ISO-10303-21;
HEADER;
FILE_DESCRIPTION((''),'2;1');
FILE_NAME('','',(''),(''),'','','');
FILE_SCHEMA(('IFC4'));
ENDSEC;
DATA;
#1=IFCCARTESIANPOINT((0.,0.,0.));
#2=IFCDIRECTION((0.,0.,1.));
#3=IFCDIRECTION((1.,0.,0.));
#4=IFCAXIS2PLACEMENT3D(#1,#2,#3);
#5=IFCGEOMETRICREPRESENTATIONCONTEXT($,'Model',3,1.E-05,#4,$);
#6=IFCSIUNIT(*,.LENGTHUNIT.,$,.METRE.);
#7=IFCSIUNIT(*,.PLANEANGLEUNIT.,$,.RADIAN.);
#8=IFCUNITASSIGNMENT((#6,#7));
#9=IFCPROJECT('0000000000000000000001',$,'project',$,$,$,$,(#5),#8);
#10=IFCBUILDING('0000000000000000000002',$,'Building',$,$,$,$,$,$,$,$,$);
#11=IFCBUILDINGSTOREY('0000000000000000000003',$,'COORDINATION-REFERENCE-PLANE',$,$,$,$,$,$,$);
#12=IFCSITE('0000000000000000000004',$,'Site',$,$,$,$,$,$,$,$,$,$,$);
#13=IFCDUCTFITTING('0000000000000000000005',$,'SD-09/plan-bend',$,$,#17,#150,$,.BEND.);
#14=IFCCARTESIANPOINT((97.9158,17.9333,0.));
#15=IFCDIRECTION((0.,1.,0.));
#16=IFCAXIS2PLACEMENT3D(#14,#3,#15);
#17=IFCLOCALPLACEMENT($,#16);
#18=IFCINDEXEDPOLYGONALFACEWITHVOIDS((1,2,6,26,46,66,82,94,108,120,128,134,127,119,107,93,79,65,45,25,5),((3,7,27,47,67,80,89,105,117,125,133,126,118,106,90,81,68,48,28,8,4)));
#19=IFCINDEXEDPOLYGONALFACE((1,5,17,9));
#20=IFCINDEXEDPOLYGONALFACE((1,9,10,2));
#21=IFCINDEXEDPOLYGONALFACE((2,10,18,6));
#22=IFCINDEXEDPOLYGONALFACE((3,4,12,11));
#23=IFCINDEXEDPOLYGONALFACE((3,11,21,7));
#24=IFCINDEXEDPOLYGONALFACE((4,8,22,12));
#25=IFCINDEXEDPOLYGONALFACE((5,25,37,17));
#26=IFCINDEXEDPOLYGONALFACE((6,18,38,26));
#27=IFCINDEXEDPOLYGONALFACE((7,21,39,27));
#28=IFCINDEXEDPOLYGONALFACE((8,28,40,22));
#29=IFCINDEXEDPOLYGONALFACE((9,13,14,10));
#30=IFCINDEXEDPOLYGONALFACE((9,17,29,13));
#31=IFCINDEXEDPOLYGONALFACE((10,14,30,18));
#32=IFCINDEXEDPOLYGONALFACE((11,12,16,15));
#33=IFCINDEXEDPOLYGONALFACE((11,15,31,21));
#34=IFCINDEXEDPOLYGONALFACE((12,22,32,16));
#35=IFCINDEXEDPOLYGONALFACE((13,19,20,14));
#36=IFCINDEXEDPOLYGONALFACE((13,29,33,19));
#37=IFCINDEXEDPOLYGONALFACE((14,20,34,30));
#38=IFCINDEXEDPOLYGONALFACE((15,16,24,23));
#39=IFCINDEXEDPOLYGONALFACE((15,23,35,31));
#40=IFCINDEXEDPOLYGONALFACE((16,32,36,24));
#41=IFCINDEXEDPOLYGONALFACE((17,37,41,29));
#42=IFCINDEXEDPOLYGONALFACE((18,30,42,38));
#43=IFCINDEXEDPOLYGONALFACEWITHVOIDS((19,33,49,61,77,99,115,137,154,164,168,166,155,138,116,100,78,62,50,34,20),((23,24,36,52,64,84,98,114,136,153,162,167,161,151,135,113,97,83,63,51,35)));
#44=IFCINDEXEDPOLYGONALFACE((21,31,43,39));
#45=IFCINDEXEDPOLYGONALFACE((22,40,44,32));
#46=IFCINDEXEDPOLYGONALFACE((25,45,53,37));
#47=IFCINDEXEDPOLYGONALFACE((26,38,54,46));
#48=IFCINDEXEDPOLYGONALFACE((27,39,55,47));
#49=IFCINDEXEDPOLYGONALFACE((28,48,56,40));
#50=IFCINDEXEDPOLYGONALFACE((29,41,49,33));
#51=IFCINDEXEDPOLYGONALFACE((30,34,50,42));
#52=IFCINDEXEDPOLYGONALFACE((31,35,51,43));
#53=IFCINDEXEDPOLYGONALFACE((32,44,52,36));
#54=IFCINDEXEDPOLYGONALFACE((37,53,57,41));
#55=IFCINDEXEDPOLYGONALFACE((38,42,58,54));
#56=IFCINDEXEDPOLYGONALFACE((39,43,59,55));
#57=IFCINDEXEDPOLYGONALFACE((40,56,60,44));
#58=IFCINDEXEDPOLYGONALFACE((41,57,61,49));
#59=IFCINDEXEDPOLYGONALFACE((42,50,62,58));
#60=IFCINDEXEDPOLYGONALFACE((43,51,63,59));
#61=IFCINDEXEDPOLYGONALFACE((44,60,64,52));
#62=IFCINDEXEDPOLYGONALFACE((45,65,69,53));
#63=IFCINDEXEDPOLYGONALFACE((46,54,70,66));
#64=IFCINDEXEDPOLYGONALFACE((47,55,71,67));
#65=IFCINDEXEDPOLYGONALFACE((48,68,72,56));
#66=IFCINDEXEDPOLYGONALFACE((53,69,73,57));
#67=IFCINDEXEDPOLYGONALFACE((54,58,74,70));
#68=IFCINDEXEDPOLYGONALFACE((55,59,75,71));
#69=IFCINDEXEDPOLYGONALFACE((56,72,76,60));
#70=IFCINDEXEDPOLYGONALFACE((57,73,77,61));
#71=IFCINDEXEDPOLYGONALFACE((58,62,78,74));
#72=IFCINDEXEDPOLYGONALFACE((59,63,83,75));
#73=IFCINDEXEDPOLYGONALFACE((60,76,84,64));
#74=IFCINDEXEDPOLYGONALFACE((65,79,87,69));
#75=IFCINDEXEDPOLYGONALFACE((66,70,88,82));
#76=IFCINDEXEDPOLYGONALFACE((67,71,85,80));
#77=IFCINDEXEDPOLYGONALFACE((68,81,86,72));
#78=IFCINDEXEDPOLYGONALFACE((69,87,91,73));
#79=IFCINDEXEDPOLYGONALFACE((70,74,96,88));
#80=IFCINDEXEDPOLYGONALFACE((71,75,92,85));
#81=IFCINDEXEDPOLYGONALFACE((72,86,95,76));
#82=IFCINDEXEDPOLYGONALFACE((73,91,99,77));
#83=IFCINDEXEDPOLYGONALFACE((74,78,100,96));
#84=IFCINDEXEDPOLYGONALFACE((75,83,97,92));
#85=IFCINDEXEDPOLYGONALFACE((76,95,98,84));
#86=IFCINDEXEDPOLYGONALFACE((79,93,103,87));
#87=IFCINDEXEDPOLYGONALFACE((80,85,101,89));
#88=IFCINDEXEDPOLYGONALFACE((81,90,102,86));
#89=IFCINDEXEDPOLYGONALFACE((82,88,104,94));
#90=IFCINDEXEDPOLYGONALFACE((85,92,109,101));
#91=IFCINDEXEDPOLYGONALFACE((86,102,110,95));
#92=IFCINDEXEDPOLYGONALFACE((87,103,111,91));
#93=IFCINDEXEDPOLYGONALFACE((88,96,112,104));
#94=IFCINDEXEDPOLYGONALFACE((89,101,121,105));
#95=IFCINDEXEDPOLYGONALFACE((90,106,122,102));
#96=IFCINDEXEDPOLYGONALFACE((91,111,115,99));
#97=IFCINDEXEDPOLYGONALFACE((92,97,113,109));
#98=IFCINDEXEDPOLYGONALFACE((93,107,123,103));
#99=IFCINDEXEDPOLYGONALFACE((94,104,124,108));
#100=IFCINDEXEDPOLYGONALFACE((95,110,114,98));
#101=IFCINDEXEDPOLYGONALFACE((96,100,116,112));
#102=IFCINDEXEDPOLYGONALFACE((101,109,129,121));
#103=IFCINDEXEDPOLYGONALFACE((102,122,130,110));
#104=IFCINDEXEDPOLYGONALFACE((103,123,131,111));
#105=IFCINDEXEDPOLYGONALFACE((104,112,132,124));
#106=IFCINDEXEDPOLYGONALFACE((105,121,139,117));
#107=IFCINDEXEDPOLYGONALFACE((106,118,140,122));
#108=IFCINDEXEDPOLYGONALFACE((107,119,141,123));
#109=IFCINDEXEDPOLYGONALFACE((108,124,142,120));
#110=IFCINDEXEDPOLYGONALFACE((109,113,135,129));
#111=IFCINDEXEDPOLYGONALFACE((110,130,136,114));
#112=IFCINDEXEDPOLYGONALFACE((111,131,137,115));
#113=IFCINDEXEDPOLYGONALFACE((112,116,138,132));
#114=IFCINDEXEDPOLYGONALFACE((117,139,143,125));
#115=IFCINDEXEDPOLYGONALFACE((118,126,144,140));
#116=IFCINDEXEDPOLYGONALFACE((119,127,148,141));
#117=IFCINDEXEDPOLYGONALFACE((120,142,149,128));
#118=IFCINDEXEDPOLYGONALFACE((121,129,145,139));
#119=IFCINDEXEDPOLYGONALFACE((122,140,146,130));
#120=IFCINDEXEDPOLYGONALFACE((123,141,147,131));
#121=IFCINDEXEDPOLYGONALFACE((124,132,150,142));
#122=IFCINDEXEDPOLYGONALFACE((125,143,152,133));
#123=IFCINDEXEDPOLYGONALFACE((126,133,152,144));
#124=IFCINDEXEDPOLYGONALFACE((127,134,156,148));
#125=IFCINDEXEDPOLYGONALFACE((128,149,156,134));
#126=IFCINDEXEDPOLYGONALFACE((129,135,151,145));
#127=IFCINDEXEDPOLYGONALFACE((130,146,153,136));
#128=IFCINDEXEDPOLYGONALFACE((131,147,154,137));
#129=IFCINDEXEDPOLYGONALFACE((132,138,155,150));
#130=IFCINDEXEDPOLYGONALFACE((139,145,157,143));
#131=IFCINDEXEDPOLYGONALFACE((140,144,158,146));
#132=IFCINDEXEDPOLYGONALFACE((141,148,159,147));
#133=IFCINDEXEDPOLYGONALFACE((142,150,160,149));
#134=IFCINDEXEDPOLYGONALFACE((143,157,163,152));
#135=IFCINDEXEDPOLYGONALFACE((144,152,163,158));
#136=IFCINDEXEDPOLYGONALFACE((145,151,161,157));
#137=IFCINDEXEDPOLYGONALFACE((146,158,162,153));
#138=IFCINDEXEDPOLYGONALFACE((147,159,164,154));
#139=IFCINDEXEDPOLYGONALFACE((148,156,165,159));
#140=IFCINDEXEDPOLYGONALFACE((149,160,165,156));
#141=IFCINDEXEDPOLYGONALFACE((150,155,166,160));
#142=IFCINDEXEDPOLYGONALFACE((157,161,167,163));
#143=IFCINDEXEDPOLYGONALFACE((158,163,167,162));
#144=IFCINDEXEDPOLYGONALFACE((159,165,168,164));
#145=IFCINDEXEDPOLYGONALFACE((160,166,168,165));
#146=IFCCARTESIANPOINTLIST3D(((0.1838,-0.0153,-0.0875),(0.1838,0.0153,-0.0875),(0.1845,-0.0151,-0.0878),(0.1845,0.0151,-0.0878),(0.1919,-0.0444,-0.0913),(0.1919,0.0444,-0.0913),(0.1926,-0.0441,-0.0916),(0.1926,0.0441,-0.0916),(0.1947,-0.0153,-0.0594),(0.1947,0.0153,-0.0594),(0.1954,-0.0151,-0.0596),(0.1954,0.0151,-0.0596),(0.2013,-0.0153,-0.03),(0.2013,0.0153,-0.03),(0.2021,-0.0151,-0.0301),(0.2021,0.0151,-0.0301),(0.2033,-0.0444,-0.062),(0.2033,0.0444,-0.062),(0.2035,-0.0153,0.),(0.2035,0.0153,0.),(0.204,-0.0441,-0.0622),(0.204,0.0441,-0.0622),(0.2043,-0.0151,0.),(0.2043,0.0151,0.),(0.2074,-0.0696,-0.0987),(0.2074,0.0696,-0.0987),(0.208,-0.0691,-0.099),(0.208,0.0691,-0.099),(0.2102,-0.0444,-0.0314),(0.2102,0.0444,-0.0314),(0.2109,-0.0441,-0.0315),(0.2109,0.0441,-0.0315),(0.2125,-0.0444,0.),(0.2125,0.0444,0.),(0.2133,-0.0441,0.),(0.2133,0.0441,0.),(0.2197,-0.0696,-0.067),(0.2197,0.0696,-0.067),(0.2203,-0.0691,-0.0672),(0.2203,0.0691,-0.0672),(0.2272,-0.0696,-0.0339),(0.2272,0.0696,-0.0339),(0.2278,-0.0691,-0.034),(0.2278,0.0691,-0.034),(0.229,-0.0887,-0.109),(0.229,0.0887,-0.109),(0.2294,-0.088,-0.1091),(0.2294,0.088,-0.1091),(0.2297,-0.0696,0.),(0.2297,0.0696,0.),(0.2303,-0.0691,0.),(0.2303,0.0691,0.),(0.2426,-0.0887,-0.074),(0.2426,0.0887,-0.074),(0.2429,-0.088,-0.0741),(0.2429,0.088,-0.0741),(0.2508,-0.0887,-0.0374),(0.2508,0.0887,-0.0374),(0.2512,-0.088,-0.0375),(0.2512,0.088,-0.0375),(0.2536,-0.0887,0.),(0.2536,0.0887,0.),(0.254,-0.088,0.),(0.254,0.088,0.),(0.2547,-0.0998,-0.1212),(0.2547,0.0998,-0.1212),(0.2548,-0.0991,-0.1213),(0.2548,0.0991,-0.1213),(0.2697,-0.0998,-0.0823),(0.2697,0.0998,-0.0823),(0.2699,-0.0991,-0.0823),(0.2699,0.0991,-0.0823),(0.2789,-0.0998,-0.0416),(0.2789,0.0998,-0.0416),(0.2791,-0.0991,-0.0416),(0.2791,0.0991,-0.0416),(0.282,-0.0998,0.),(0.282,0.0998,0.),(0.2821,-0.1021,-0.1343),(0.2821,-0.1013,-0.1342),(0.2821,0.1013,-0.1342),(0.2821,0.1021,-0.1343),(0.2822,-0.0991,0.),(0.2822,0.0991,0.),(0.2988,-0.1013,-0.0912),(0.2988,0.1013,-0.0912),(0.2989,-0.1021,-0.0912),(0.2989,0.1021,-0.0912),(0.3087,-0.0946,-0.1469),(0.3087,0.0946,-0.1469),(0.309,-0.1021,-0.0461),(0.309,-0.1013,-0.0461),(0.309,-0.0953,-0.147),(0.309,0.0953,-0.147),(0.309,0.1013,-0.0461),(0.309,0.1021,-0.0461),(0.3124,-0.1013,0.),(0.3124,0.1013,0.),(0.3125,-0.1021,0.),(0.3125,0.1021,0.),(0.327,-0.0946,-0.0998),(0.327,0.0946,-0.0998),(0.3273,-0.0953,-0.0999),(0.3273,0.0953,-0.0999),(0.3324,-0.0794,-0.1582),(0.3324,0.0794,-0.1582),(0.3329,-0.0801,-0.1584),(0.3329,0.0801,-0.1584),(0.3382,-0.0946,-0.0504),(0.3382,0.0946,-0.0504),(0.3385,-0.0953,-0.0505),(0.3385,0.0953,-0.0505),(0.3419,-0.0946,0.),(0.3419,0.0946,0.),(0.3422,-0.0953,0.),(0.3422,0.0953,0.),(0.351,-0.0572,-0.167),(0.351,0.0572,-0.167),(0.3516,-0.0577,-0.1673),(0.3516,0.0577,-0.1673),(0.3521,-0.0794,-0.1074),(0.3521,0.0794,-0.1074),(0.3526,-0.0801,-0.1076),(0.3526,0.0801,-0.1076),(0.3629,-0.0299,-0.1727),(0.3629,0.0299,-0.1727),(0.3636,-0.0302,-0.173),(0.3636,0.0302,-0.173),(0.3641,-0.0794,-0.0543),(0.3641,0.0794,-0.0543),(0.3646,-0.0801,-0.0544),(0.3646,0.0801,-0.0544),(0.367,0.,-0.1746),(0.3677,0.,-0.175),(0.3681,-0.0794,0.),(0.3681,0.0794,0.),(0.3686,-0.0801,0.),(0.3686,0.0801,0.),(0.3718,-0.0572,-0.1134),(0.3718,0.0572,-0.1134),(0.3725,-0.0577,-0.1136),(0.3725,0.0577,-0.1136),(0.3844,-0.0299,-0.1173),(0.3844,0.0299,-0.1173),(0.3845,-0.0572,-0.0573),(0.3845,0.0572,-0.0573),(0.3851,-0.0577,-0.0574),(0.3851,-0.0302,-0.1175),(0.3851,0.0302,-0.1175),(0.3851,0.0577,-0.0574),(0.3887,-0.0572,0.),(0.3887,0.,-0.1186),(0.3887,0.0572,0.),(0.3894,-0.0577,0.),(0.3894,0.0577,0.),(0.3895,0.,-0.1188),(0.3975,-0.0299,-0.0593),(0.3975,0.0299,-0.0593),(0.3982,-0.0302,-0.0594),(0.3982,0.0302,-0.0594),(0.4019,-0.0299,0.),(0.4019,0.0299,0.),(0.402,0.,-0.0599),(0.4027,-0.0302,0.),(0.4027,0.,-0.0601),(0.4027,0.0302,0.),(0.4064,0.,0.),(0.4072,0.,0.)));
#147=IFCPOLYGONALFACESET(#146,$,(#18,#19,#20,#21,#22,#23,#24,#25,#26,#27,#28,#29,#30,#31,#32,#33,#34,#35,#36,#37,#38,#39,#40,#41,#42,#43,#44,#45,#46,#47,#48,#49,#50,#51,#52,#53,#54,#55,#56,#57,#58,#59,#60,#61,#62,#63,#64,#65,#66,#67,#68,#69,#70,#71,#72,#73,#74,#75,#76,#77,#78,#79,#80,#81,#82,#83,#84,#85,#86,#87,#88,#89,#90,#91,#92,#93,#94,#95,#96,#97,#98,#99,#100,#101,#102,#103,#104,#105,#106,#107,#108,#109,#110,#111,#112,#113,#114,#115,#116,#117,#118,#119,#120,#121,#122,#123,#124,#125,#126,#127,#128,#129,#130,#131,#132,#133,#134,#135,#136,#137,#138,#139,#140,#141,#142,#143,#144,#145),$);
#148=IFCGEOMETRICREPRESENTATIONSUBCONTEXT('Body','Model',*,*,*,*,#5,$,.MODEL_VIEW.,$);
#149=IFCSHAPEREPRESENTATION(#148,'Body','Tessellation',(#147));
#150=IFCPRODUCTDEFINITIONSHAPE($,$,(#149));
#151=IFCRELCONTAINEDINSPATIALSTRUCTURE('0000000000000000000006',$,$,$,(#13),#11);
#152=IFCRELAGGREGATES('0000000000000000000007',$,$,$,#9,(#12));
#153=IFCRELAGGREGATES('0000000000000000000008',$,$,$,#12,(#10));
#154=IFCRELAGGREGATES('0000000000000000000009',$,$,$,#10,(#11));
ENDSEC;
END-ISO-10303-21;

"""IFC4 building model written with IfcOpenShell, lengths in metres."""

from ifc_helpers import new_model, entity, si_unit, frame, origin_with_axes, place, context, subcontext, project, spatial, element, save


model = new_model("IFC4")

# Units and contexts
model_context_1 = context("Model", 3, precision=1e-05, world=origin_with_axes())
body_context_1 = subcontext(model_context_1, "Body", "Model", "MODEL_VIEW")
ifc_project = project(units=[si_unit("LENGTHUNIT", "METRE"), si_unit("PLANEANGLEUNIT", "RADIAN")], contexts=[model_context_1])

# Site, building, storey
site = spatial("IfcSite", under=ifc_project, Name="Site")
building = spatial("IfcBuilding", under=site, Name="Building")
storey = spatial("IfcBuildingStorey", under=building, Name="COORDINATION-REFERENCE-PLANE")

# Duct fitting
duct_fitting_1_placement = place(None, frame((97.9158, 17.9333, 0.0), z_axis=(1.0, 0.0, 0.0), x_axis=(0.0, 1.0, 0.0)))
element("IfcDuctFitting", 1, at=duct_fitting_1_placement, inside=storey, Name="SD-09/plan-bend", PredefinedType="BEND", context=body_context_1, shape_type="SweptSolid", body=[
    entity("IfcRevolvedAreaSolid", entity("IfcCircleHollowProfileDef", "AREA", None, entity("IfcAxis2Placement2D", entity("IfcCartesianPoint", [0.3048, 0.0])), 0.1024, 0.0008), entity("IfcAxis2Placement3D", entity("IfcCartesianPoint", [0.0, 0.0, 0.0]), entity("IfcDirection", [0.0, 0.0, 1.0]), entity("IfcDirection", [1.0, 0.0, 0.0])), entity("IfcAxis1Placement", entity("IfcCartesianPoint", [0.0, 0.0, 0.0]), entity("IfcDirection", [0.0, 1.0, 0.0])), 0.444153),
])

save(model, "model.ifc")
